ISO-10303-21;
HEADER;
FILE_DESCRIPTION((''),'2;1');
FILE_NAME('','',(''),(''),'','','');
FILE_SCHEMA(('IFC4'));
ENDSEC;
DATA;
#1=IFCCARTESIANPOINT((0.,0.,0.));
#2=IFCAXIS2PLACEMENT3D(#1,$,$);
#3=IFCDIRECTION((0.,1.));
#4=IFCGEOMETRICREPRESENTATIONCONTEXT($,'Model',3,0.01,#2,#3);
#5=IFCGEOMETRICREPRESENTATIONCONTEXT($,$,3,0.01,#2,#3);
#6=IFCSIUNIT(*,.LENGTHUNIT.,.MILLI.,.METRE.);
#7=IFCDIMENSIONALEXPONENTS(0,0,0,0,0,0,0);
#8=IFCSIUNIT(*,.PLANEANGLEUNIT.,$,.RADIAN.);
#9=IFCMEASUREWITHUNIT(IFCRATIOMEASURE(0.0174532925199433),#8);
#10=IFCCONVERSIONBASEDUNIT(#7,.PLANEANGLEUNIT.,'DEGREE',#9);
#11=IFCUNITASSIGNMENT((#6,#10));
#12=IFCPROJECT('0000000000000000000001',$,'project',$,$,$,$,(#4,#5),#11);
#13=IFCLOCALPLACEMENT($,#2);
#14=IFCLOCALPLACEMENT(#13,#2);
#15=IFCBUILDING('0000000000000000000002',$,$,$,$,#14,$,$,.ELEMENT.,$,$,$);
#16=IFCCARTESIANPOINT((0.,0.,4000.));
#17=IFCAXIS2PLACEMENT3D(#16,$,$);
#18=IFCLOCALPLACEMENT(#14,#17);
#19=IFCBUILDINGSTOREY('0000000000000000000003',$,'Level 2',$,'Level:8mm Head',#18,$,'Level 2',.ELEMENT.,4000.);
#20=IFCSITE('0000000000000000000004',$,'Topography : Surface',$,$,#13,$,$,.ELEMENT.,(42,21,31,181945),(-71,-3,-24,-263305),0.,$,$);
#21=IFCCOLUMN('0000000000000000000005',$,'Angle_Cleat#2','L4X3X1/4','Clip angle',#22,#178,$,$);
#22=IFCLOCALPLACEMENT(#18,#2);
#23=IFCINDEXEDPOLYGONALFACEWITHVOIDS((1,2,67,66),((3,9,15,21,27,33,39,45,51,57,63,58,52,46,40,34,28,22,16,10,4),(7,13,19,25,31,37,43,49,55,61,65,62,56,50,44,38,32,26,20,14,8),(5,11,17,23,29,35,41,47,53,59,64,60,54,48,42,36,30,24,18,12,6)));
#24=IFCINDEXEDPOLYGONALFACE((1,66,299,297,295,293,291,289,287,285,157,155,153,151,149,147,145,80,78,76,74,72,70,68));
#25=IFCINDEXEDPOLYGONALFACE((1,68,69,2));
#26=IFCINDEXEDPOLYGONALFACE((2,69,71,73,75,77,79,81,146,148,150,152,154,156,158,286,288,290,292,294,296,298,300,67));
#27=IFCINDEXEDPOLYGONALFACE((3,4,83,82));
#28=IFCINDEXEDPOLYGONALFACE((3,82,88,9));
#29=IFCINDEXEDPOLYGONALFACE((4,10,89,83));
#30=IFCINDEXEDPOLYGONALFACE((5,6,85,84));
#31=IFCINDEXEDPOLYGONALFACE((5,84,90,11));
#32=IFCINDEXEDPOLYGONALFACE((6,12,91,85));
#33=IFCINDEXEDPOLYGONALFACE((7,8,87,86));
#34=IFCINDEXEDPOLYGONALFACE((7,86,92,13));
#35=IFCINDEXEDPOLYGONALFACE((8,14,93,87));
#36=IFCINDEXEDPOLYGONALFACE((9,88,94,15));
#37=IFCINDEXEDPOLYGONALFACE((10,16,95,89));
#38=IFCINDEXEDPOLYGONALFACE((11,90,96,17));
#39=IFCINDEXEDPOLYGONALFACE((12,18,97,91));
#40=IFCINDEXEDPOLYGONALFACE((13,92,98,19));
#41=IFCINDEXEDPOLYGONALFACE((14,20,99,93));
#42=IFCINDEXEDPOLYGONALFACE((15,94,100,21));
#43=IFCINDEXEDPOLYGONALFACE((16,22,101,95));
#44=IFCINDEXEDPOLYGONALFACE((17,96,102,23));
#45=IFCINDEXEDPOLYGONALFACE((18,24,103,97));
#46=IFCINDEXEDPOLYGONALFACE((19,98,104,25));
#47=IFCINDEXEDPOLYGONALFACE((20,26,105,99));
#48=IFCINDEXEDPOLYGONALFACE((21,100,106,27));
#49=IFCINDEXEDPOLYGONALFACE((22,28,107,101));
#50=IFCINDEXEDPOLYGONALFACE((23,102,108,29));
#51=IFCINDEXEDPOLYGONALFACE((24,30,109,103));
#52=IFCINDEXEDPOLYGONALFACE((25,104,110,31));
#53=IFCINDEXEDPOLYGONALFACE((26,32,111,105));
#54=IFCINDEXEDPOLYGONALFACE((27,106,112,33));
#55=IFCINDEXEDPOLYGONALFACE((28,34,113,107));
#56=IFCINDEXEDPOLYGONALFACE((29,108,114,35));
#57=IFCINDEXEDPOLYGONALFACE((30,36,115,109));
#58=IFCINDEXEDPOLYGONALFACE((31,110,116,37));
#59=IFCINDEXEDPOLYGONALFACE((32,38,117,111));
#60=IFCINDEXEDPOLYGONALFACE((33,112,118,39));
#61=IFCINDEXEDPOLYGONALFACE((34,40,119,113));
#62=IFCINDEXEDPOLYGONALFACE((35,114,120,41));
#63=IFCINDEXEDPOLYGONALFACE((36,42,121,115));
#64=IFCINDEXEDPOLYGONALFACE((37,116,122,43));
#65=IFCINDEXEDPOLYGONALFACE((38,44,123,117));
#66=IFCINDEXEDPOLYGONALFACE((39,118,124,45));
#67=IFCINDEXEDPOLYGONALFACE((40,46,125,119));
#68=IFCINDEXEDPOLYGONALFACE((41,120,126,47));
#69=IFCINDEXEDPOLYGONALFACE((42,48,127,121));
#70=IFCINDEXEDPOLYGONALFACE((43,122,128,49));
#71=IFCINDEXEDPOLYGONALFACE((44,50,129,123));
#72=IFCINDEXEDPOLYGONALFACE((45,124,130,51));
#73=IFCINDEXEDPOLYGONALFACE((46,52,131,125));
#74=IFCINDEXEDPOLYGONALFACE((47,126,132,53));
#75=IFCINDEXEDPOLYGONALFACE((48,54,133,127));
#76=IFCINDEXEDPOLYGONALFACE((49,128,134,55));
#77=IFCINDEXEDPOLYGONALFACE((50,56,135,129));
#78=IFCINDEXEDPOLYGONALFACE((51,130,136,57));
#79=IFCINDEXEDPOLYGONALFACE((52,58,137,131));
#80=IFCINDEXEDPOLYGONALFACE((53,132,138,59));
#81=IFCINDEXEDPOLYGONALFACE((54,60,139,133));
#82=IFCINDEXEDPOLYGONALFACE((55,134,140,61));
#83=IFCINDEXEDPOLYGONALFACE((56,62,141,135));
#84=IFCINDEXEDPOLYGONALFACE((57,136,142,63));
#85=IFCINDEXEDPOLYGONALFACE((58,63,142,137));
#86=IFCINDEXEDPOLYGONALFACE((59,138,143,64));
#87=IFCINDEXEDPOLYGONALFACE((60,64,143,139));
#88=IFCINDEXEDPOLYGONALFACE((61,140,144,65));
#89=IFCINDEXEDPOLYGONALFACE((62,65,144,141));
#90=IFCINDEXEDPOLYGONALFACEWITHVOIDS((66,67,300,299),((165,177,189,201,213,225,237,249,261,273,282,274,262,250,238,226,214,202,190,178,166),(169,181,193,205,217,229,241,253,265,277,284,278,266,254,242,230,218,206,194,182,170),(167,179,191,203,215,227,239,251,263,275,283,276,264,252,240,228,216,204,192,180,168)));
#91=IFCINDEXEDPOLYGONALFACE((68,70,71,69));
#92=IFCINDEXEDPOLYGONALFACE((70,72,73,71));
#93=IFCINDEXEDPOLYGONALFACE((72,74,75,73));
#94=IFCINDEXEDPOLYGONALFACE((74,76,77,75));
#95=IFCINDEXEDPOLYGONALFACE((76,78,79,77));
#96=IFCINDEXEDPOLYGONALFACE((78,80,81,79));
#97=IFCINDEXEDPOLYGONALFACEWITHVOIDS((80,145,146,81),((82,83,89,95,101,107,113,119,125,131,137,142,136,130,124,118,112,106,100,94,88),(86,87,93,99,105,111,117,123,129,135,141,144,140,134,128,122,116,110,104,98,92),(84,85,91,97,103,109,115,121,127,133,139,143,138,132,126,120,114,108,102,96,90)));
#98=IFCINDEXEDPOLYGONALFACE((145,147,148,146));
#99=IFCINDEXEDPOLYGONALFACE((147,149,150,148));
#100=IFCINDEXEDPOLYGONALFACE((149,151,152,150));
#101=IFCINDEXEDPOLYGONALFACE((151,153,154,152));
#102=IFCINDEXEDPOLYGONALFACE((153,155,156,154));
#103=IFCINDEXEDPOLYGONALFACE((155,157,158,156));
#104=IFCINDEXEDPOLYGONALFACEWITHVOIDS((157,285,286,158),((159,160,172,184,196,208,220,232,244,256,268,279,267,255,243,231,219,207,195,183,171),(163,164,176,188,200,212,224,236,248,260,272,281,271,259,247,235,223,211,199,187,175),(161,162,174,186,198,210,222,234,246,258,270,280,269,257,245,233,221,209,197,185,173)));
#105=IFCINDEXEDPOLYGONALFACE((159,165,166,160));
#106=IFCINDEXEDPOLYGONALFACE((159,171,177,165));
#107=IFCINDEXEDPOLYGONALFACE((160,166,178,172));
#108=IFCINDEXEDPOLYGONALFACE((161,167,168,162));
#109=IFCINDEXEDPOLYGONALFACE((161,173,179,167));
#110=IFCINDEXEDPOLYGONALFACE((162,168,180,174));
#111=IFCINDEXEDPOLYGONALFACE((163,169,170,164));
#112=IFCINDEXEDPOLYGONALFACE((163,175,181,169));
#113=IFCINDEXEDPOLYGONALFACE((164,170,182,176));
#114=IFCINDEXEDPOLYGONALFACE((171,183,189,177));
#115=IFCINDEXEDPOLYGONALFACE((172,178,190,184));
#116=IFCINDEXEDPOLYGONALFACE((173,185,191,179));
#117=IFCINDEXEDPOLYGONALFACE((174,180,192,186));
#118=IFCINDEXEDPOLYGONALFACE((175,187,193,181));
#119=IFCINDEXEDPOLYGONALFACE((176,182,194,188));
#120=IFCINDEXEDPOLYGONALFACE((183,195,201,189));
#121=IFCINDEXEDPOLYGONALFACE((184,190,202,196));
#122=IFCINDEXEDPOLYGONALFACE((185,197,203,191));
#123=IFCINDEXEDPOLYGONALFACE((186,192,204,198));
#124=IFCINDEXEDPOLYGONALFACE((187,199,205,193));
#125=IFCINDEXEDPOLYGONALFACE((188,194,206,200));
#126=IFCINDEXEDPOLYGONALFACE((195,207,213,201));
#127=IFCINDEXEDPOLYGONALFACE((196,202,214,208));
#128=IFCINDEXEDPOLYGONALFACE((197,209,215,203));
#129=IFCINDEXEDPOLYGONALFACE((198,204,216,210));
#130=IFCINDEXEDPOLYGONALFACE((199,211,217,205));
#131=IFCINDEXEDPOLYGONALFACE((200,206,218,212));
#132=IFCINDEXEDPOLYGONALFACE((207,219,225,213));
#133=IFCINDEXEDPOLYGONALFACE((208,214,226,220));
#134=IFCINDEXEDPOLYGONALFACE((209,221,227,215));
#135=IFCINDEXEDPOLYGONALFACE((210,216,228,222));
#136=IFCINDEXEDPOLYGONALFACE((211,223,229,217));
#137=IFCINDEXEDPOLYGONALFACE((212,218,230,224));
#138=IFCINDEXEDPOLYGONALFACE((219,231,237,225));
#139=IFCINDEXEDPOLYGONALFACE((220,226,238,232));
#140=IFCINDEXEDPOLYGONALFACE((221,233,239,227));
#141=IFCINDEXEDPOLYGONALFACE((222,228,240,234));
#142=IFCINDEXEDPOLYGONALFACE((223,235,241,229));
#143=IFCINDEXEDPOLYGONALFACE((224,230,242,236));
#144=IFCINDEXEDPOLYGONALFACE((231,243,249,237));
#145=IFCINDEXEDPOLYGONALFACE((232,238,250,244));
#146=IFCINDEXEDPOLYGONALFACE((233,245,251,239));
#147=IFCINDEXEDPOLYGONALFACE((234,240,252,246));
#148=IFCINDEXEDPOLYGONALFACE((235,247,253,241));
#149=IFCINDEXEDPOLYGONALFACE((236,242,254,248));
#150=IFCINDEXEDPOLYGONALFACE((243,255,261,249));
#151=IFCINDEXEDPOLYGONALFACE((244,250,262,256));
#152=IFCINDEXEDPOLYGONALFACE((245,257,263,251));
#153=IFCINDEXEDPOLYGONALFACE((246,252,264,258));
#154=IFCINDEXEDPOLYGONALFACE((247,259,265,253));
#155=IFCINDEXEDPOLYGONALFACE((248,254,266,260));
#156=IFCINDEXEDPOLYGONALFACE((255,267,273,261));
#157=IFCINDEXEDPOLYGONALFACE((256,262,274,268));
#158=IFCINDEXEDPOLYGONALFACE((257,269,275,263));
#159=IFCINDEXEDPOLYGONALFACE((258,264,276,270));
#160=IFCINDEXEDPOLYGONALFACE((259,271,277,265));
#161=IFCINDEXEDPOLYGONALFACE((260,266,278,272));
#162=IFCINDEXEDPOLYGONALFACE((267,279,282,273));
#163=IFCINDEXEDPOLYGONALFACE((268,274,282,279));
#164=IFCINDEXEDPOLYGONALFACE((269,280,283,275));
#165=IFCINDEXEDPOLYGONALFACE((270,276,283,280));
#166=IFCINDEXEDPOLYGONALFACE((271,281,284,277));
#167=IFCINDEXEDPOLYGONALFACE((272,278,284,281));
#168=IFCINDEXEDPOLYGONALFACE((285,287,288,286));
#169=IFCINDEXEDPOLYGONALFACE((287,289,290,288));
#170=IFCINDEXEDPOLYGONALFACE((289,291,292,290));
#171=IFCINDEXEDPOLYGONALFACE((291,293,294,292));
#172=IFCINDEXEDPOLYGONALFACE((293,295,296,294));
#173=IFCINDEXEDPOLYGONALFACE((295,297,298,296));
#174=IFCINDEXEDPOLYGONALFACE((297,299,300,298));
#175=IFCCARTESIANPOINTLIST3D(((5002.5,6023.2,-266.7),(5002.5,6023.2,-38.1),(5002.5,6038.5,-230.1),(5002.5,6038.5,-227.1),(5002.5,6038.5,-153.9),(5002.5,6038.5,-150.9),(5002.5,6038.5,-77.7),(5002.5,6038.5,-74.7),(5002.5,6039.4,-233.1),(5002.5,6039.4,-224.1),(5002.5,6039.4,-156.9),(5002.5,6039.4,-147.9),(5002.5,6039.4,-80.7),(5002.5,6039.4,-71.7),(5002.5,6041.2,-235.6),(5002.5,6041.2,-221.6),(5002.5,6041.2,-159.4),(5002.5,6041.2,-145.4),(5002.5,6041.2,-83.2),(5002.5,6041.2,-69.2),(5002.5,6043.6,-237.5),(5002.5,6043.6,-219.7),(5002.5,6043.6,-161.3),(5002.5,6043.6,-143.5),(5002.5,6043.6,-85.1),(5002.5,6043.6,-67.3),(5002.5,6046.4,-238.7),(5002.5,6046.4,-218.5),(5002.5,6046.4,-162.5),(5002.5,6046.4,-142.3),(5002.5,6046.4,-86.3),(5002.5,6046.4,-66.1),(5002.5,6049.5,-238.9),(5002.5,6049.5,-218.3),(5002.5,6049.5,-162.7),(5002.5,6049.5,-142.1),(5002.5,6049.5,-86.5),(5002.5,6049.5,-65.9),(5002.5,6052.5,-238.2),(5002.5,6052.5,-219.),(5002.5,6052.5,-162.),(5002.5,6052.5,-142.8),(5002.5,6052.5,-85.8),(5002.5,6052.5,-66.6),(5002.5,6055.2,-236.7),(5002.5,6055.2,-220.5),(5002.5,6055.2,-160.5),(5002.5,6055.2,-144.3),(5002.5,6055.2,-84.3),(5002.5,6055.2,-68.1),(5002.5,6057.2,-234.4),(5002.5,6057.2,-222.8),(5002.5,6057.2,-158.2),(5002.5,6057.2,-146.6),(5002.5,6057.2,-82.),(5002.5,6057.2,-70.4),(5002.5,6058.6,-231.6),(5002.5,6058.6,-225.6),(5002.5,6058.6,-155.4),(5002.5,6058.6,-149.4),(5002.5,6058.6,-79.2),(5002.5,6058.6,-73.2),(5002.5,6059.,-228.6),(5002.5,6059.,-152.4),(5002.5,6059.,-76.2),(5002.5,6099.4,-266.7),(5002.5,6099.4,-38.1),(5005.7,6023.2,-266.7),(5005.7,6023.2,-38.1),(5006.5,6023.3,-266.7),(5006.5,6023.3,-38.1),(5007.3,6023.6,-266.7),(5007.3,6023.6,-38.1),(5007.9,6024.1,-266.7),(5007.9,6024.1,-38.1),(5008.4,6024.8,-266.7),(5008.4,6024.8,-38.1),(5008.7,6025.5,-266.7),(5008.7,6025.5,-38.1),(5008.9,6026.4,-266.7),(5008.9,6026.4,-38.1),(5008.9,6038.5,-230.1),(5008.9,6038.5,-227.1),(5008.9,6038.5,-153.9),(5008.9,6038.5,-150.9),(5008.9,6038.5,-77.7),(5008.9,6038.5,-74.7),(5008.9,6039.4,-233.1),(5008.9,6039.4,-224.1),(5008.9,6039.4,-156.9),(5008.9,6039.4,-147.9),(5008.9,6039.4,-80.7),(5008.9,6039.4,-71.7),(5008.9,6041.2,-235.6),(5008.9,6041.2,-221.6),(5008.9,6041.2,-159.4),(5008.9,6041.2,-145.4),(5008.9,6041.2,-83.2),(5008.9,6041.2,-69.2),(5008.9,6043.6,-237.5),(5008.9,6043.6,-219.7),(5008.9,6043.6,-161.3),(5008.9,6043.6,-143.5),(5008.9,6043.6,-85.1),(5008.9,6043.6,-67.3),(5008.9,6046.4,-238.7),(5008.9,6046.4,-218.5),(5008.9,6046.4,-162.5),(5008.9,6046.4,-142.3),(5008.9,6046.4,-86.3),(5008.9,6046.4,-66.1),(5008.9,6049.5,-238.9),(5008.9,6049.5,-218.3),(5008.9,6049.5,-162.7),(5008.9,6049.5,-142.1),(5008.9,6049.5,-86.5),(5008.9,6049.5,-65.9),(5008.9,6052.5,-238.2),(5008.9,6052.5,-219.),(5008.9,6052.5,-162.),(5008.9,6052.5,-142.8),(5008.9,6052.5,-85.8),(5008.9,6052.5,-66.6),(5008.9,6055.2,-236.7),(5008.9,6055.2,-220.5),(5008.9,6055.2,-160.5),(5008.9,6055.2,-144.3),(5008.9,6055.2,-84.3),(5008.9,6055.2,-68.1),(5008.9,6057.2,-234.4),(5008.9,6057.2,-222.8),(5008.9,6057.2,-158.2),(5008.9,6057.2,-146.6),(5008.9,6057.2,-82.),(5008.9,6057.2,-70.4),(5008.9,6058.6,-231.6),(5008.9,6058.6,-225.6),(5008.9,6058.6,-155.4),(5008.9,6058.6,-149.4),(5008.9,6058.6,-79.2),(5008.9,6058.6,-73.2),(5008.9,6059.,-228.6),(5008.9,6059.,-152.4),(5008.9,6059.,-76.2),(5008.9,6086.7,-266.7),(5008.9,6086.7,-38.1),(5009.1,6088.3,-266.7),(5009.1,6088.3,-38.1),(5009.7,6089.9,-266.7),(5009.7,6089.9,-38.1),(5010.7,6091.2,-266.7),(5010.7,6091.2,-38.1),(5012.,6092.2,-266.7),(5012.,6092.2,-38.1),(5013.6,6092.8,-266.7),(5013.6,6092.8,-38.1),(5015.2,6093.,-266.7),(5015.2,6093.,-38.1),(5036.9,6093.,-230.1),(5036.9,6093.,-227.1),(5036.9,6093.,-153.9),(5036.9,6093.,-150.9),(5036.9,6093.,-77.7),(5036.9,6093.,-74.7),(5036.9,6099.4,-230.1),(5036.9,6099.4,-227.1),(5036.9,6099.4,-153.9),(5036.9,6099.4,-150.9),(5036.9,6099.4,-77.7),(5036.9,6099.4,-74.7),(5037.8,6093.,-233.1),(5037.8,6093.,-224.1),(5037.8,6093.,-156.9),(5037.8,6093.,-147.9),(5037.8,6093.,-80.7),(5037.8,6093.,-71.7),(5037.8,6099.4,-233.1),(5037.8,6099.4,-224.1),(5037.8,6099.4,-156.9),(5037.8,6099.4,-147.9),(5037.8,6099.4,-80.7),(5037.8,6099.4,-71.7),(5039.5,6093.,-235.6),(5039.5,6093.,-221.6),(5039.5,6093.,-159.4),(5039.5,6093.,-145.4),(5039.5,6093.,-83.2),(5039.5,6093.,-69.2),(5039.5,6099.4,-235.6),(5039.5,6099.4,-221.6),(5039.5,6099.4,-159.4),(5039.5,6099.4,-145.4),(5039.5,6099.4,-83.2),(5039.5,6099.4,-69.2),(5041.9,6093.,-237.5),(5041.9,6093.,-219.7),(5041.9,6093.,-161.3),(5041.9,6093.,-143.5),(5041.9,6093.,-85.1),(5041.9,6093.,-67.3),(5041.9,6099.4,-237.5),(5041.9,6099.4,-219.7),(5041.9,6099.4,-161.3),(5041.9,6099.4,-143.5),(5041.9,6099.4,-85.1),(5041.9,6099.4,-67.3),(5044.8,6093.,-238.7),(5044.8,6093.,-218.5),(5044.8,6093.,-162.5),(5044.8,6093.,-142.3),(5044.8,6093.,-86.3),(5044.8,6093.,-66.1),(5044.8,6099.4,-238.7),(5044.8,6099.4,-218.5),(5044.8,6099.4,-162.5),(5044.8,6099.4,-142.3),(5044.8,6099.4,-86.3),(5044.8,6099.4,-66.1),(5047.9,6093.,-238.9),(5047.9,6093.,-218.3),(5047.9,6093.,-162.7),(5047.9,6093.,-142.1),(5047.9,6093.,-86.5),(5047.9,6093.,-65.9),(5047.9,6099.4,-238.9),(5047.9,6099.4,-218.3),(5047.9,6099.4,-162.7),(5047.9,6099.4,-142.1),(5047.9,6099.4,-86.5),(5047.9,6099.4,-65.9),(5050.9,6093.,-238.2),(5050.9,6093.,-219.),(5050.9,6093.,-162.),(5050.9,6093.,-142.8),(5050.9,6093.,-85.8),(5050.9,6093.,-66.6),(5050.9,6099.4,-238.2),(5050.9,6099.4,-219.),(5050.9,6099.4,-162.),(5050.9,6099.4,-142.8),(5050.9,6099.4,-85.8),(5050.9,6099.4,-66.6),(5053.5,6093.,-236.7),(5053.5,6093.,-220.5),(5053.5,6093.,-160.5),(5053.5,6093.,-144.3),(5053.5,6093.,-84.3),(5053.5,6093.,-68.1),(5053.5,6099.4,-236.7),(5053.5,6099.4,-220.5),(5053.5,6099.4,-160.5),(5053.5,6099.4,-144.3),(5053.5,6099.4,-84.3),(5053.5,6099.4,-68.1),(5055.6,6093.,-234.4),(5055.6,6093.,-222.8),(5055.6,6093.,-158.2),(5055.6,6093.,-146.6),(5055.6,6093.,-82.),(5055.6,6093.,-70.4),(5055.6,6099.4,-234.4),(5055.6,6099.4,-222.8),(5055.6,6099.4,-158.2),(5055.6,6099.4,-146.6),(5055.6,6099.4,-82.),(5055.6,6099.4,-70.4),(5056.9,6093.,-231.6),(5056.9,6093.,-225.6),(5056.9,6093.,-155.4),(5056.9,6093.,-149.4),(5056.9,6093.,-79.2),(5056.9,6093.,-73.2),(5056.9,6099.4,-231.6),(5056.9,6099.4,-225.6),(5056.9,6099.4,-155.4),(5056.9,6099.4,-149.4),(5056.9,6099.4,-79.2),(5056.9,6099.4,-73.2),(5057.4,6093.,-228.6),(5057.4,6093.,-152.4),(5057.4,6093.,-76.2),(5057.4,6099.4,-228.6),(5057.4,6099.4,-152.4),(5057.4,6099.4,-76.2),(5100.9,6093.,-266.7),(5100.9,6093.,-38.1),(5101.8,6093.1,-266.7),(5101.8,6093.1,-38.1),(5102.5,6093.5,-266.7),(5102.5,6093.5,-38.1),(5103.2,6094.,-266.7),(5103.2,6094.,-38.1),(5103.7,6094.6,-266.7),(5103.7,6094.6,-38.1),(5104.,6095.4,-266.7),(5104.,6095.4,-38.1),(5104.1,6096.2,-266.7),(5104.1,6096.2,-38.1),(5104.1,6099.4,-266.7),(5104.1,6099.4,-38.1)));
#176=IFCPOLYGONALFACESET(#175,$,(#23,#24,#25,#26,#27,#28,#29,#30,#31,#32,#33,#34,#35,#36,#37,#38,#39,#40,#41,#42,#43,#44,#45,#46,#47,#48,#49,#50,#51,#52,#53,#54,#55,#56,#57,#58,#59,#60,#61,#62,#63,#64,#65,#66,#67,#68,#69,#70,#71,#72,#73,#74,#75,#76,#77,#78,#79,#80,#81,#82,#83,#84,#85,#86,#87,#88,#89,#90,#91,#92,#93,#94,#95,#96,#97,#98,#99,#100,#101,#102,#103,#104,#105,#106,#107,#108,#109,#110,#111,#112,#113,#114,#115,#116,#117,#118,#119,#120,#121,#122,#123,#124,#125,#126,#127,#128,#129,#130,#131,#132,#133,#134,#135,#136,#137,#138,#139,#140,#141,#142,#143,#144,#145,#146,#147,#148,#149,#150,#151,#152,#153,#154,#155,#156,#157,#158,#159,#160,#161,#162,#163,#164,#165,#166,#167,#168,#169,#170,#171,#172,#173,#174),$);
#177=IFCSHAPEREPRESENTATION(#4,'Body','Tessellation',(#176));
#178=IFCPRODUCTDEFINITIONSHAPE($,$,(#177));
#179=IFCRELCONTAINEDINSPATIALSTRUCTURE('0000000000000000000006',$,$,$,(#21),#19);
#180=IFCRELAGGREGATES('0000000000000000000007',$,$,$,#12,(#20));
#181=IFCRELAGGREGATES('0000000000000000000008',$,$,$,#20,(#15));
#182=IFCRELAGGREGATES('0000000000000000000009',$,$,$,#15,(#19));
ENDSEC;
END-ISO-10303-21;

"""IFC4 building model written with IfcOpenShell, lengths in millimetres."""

from ifc_helpers import new_model, entity, si_unit, converted_unit, direction, frame, frame_2d, origin, origin_2d_with_axis, place, context, project, spatial, circle, l_section, extrude, element, save


model = new_model("IFC4")

# Units and contexts
model_context = context("Model", 3, precision=0.01, world=origin(), true_north=direction((0.0, 1.0)))
context_of_model = context(None, 3, precision=0.01, world=origin(), true_north=direction((0.0, 1.0)))
ifc_project = project(units=[si_unit("LENGTHUNIT", "METRE", prefix="MILLI"), converted_unit("PLANEANGLEUNIT", "DEGREE", entity("IfcRatioMeasure", 0.0174532925199433), si_unit("PLANEANGLEUNIT", "RADIAN"), dimensions=[0, 0, 0, 0, 0, 0, 0])], contexts=[model_context, context_of_model])

# Site, building, storey
site_placement = place(None, origin())
site = spatial("IfcSite", under=ifc_project, at=site_placement, Name="Topography : Surface", CompositionType="ELEMENT", RefLatitude=(42, 21, 31, 181945), RefLongitude=(-71, -3, -24, -263305), RefElevation=0.0)
building_placement = place(site_placement, origin())
building = spatial("IfcBuilding", under=site, at=building_placement, CompositionType="ELEMENT")
storey_placement = place(building_placement, frame((0.0, 0.0, 4000.0)))
storey = spatial("IfcBuildingStorey", under=building, at=storey_placement, Name="Level 2", ObjectType="Level:8mm Head", LongName="Level 2", CompositionType="ELEMENT", Elevation=4000.0)

# Column, openings
column_1_placement = place(storey_placement, frame((5033.6, 6081.1, -38.1), z_axis=(0.0, 0.0, 1.0), x_axis=(0.0, -1.0, 0.0)))
column_1 = element("IfcColumn", 1, at=column_1_placement, inside=storey, Name="Angle_Cleat#2", Description="L4X3X1/4", ObjectType="Clip angle", context=model_context, shape_type="SweptSolid", body=[
    extrude(l_section(Depth=101.6, Width=76.2, Thickness=6.3, FilletRadius=6.3, EdgeRadius=3.2, at=frame_2d((19.8, 19.7))), origin(), (0.0, 0.0, -1.0), 228.6),
])
opening_1_placement = place(column_1_placement, frame((32.4, -31.5, -114.3), z_axis=(0.0, 1.0, 0.0), x_axis=(-1.0, 0.0, 0.0)))
element("IfcOpeningElement", 2, at=opening_1_placement, cuts=column_1, ObjectType="Opening", context=model_context, shape_type="SweptSolid", body=[
    extrude(circle(Radius=10.3, at=origin_2d_with_axis()), origin(), (0.0, 0.0, 1.0), 7.3),
])
opening_2_placement = place(column_1_placement, frame((32.4, -31.5, -114.3), z_axis=(0.0, 1.0, 0.0), x_axis=(-1.0, 0.0, 0.0)))
element("IfcOpeningElement", 3, at=opening_2_placement, cuts=column_1, ObjectType="Opening", context=model_context, shape_type="SweptSolid", body=[
    extrude(circle(Radius=10.3, at=frame_2d((0.0, 76.2), x_axis=(1.0, 0.0))), origin(), (0.0, 0.0, 1.0), 7.3),
])
opening_3_placement = place(column_1_placement, frame((32.4, -31.5, -114.3), z_axis=(0.0, 1.0, 0.0), x_axis=(-1.0, 0.0, 0.0)))
element("IfcOpeningElement", 4, at=opening_3_placement, cuts=column_1, ObjectType="Opening", context=model_context, shape_type="SweptSolid", body=[
    extrude(circle(Radius=10.3, at=frame_2d((0.0, -76.2), x_axis=(1.0, 0.0))), origin(), (0.0, 0.0, 1.0), 7.3),
])
opening_4_placement = place(column_1_placement, frame((-11.6, 13.5, -114.3), z_axis=(-1.0, 0.0, 0.0), x_axis=(0.0, 1.0, 0.0)))
element("IfcOpeningElement", 5, at=opening_4_placement, cuts=column_1, ObjectType="Opening", context=model_context, shape_type="SweptSolid", body=[
    extrude(circle(Radius=10.3, at=origin_2d_with_axis()), origin(), (0.0, 0.0, 1.0), 7.3),
])
opening_5_placement = place(column_1_placement, frame((-11.6, 13.5, -114.3), z_axis=(-1.0, 0.0, 0.0), x_axis=(0.0, 1.0, 0.0)))
element("IfcOpeningElement", 6, at=opening_5_placement, cuts=column_1, ObjectType="Opening", context=model_context, shape_type="SweptSolid", body=[
    extrude(circle(Radius=10.3, at=frame_2d((0.0, 76.2), x_axis=(1.0, 0.0))), origin(), (0.0, 0.0, 1.0), 7.3),
])
opening_6_placement = place(column_1_placement, frame((-11.6, 13.5, -114.3), z_axis=(-1.0, 0.0, 0.0), x_axis=(0.0, 1.0, 0.0)))
element("IfcOpeningElement", 7, at=opening_6_placement, cuts=column_1, ObjectType="Opening", context=model_context, shape_type="SweptSolid", body=[
    extrude(circle(Radius=10.3, at=frame_2d((0.0, -76.2), x_axis=(1.0, 0.0))), origin(), (0.0, 0.0, 1.0), 7.3),
])

save(model, "model.ifc")
